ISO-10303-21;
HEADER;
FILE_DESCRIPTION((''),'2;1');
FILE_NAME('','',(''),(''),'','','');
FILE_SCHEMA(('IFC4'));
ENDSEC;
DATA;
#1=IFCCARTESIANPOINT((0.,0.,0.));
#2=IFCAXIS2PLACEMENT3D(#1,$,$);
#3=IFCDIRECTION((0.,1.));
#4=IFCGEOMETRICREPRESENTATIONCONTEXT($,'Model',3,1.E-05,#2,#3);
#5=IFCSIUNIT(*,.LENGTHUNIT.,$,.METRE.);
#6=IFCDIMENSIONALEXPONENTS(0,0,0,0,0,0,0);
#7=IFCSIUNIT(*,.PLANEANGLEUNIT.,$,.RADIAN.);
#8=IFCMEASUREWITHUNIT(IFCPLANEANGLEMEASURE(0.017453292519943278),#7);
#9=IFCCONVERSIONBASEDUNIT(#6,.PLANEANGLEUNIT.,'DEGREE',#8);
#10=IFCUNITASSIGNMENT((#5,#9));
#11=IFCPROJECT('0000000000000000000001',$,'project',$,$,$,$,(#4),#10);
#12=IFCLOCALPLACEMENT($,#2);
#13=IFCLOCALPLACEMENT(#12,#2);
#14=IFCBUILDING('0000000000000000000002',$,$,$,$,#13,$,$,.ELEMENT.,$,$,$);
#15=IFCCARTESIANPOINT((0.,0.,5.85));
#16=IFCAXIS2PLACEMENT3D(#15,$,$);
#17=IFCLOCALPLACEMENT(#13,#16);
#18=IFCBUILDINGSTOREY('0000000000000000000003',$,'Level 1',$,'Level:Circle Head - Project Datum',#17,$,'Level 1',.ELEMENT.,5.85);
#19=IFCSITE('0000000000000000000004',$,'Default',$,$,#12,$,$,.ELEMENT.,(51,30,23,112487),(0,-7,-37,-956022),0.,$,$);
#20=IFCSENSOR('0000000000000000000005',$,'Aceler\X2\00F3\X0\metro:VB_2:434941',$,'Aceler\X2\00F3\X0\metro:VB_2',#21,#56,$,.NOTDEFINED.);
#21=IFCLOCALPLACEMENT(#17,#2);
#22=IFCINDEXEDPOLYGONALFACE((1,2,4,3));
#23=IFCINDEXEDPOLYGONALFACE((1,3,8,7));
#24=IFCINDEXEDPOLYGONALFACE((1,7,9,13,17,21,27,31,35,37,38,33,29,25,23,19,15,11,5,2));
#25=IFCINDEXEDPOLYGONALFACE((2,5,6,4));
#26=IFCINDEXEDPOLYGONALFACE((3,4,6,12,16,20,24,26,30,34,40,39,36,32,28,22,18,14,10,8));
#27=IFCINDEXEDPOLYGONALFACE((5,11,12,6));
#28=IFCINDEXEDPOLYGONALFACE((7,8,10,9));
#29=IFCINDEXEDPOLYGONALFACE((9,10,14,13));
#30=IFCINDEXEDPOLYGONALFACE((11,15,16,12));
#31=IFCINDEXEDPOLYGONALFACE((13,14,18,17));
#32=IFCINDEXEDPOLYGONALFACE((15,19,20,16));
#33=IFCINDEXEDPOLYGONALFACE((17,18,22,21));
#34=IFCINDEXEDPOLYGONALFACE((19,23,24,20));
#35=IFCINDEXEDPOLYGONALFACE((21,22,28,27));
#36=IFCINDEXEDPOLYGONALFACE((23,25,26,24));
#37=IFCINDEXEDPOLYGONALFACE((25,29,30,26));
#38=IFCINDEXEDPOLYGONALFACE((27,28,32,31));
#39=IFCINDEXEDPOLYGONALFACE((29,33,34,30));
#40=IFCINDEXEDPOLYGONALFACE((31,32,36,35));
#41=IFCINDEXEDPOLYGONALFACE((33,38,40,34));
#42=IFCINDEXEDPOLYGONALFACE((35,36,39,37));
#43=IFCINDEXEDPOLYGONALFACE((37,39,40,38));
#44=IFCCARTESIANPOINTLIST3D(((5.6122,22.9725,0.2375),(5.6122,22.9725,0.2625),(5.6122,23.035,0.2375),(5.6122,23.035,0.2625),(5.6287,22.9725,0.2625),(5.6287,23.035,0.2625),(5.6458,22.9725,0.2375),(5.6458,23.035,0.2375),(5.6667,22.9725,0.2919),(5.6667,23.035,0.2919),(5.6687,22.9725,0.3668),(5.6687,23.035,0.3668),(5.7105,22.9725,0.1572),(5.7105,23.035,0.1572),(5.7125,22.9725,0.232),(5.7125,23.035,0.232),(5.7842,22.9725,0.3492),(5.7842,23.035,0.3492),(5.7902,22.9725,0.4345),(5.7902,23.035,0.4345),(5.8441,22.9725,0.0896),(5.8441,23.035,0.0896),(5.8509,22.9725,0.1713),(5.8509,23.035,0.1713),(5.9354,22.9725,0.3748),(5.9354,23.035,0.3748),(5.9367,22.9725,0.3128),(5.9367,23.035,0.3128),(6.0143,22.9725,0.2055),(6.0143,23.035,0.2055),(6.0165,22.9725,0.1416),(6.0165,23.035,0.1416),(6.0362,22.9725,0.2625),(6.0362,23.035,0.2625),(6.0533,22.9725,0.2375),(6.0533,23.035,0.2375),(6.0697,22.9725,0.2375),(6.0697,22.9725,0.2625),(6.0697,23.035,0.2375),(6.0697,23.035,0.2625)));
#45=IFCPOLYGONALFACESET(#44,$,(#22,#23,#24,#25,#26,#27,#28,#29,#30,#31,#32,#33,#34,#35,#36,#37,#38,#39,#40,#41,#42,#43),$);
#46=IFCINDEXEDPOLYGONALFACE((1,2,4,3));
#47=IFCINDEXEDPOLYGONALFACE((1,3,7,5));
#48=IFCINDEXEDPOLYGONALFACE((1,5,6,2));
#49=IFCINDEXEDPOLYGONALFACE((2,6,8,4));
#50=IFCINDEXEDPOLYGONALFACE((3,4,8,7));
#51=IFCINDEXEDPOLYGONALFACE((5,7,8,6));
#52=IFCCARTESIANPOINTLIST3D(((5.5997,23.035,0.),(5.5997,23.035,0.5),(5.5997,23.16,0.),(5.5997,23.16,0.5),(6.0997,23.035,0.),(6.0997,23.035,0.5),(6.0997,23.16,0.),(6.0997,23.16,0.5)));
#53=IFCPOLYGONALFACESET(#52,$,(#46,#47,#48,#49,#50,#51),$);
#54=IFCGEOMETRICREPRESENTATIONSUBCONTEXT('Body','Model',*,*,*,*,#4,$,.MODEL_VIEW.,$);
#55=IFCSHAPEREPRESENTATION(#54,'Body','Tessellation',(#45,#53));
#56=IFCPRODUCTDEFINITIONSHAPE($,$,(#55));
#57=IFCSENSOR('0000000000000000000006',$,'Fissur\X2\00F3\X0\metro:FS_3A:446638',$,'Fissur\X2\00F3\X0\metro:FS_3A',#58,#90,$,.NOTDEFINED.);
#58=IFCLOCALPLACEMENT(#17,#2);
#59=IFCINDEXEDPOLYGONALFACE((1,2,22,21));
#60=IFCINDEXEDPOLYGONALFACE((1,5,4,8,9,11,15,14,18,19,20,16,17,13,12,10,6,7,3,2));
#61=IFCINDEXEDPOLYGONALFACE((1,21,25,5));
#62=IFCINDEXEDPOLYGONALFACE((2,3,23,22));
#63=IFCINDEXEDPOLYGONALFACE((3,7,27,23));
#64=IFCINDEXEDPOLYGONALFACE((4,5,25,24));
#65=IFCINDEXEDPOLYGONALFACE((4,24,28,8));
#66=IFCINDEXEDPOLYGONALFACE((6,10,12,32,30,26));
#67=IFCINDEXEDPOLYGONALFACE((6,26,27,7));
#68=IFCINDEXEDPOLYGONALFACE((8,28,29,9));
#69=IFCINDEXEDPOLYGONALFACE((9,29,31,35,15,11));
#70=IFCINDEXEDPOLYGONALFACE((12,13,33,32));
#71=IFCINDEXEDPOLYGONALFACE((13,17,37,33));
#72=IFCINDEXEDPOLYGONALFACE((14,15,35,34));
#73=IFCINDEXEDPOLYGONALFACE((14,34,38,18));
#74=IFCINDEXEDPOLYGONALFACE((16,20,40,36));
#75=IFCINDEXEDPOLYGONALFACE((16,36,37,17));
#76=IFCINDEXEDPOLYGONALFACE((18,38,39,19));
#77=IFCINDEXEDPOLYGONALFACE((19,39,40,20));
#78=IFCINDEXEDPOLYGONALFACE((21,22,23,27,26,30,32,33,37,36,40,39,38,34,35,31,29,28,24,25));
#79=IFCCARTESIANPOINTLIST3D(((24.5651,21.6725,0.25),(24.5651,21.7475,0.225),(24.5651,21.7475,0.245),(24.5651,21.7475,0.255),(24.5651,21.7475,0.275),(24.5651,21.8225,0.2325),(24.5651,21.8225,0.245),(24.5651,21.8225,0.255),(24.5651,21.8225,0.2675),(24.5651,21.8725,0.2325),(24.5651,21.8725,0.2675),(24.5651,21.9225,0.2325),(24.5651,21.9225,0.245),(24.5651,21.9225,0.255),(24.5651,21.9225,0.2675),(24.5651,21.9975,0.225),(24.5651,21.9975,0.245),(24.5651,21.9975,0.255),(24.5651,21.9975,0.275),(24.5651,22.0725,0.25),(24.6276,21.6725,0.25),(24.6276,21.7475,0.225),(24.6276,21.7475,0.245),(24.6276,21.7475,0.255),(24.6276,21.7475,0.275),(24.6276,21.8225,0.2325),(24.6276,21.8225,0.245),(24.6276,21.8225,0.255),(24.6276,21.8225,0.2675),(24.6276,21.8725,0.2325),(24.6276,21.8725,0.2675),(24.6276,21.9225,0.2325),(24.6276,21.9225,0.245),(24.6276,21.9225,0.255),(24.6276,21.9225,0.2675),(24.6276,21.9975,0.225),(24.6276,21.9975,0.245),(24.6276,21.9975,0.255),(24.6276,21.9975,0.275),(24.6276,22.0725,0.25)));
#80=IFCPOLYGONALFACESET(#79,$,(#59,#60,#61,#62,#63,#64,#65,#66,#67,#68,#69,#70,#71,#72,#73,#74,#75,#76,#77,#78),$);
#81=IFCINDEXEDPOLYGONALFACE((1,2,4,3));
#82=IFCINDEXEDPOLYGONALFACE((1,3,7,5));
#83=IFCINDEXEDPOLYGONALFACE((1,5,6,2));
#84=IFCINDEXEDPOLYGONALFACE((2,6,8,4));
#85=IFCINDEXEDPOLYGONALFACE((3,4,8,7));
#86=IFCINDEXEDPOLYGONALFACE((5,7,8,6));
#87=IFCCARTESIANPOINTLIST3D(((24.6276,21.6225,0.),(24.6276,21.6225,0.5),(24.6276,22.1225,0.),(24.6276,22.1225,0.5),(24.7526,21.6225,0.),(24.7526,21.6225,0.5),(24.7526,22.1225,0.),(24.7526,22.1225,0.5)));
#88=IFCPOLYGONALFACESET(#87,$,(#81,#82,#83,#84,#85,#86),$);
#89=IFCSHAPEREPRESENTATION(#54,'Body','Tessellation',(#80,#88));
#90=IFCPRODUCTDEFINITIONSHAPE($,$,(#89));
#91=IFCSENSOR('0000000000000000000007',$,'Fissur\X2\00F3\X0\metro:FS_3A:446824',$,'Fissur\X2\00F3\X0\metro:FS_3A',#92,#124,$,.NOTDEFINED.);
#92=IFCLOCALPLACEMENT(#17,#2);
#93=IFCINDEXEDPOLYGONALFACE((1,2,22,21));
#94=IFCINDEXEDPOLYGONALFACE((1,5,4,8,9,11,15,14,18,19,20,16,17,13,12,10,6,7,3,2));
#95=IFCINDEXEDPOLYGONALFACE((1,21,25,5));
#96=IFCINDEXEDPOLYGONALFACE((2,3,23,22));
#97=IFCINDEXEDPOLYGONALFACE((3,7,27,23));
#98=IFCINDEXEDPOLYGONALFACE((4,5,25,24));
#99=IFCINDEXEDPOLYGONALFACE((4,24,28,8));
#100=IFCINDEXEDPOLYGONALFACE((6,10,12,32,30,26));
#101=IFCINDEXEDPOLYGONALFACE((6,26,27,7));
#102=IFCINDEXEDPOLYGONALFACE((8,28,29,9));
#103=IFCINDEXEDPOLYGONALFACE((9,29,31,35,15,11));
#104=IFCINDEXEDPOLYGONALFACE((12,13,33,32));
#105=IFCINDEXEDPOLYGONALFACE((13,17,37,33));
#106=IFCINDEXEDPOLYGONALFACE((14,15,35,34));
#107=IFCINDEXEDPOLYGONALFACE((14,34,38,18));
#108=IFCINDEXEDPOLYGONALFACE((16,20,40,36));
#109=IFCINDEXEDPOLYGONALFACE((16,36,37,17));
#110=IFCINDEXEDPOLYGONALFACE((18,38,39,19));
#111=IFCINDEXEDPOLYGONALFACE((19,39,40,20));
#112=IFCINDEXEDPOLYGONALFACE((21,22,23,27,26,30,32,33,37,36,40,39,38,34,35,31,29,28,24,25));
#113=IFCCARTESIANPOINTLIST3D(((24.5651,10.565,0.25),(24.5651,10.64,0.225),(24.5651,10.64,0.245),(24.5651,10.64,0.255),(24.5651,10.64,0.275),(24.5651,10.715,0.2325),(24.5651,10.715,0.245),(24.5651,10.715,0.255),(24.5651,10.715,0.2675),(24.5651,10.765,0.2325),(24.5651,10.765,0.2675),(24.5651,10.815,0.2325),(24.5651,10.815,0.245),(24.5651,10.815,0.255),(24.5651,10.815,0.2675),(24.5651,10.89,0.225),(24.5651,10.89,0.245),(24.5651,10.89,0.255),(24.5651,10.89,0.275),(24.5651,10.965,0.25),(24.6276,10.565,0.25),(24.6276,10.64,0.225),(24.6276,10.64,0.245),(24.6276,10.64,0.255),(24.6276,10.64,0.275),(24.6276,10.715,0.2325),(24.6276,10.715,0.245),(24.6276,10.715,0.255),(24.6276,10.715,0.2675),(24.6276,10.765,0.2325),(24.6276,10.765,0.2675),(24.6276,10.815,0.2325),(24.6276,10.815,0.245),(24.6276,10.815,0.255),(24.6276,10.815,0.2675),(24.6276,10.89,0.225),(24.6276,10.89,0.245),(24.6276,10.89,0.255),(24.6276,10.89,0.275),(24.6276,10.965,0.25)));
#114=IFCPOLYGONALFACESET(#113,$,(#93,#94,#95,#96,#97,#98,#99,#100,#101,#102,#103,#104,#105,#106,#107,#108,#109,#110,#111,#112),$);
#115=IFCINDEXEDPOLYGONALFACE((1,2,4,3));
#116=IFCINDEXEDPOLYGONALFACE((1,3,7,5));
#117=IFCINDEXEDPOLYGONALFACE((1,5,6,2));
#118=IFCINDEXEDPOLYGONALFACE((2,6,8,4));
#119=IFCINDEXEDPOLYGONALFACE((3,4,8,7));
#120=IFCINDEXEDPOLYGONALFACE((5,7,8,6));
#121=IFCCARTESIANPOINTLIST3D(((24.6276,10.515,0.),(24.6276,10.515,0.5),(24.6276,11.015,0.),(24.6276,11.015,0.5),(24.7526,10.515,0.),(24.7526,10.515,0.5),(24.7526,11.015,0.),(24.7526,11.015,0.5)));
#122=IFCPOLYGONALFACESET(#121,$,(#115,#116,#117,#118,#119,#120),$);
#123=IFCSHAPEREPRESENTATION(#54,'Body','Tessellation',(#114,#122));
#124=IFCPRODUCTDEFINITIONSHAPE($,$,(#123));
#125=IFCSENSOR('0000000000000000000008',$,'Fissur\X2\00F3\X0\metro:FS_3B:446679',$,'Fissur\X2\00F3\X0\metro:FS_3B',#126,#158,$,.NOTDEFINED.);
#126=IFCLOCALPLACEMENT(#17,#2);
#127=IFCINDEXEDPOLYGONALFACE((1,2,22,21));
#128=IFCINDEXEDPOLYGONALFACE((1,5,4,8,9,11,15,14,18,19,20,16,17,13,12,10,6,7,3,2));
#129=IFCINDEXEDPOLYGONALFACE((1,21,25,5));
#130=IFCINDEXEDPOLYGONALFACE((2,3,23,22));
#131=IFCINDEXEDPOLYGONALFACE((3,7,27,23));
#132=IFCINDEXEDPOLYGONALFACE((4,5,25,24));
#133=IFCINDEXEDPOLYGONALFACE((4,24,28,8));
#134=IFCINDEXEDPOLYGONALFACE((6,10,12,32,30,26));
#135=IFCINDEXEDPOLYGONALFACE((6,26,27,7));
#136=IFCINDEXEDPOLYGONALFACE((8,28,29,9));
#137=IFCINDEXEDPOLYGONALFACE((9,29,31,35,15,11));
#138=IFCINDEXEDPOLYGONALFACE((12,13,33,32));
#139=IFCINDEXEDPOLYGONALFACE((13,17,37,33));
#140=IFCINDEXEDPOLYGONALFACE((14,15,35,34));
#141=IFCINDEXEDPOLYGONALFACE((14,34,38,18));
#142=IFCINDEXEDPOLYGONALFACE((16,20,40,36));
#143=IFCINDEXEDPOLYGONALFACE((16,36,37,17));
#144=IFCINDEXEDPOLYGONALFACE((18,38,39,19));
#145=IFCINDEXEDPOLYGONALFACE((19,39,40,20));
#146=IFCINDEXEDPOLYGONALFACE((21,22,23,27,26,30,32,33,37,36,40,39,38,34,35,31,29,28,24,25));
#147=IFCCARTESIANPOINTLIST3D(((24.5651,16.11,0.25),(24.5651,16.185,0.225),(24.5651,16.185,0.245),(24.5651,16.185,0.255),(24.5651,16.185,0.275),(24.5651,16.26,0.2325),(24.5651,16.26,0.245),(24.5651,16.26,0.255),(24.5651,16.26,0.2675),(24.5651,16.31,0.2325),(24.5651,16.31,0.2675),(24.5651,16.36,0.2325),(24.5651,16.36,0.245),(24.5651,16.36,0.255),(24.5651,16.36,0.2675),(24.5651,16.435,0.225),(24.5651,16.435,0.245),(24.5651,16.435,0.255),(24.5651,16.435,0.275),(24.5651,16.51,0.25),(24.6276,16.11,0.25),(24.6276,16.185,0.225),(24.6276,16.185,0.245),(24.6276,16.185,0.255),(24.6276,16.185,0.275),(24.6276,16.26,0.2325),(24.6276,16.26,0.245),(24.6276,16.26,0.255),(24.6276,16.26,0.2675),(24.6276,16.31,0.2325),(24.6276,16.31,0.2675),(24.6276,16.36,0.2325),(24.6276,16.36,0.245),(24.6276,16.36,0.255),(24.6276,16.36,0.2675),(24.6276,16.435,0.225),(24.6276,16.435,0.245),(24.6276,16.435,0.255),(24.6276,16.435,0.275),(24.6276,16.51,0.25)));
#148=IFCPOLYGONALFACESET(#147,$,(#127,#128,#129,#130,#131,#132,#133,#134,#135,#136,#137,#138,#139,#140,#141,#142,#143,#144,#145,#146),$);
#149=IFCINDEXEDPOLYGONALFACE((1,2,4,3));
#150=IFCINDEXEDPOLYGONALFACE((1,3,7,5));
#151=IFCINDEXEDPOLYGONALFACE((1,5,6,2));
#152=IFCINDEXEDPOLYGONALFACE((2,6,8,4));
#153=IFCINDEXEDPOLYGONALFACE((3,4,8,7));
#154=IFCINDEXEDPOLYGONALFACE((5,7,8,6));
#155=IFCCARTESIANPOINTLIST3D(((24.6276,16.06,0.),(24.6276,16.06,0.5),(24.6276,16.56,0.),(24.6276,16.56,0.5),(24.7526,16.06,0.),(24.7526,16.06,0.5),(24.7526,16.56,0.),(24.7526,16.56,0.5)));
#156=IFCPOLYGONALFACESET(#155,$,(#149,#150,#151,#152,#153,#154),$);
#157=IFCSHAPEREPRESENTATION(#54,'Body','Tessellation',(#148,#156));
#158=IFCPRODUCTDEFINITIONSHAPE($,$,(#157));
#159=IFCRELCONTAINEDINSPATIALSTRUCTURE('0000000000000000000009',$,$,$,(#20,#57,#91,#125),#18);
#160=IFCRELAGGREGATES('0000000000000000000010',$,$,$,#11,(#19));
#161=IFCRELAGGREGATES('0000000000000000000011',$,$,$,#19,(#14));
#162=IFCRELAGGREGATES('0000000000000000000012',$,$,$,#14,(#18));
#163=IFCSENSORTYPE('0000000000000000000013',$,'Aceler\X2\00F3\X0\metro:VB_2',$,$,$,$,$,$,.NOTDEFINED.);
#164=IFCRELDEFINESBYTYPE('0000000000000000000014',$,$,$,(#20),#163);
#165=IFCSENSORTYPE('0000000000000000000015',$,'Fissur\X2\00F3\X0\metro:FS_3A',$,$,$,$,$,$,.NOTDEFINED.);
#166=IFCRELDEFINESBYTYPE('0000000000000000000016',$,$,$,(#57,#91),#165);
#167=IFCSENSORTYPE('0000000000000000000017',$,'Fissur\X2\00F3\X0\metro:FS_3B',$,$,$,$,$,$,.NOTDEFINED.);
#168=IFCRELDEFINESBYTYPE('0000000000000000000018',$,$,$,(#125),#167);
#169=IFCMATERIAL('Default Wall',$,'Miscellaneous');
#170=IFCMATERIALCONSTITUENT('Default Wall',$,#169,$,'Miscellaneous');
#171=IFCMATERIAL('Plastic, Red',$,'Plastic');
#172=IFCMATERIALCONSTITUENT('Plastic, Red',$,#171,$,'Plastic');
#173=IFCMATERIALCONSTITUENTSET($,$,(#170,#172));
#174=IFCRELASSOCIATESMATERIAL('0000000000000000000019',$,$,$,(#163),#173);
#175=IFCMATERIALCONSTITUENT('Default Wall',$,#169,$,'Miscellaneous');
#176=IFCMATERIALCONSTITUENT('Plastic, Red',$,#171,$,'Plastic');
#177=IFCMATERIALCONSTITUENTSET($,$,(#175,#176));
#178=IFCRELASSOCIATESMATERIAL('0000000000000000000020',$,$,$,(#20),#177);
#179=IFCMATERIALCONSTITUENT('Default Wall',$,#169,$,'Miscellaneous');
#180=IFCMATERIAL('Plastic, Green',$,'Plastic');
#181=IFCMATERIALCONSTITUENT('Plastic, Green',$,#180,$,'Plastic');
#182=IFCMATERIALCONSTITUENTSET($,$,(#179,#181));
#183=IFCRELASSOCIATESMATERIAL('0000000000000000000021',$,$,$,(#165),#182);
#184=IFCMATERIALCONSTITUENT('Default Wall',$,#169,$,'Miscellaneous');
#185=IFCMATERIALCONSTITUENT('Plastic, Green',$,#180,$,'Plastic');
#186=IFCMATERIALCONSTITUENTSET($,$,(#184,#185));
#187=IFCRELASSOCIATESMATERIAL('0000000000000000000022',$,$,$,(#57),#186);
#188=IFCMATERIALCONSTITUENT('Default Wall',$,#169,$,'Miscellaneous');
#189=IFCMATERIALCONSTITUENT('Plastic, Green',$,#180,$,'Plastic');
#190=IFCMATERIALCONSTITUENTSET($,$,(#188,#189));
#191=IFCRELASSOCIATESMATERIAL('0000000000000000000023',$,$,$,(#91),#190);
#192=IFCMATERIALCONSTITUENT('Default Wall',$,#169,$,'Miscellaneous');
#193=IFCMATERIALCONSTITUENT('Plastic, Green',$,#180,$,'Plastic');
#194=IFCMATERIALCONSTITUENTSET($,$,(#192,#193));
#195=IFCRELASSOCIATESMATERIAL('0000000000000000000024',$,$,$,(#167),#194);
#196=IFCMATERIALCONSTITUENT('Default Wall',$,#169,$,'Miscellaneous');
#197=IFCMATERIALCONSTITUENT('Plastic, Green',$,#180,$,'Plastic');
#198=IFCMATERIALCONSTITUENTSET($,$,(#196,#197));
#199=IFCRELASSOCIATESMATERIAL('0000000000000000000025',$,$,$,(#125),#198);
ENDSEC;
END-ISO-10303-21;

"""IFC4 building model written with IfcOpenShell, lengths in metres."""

from ifc_helpers import new_model, entity, si_unit, converted_unit, direction, frame, origin, place, context, subcontext, project, spatial, indexed_curve, outline, extrude, source, transform, mapped, material, constituent, constituent_set, type_object, type_shapes, element, save


model = new_model("IFC4")

# Units and contexts
model_context = context("Model", 3, precision=1e-05, world=origin(), true_north=direction((0.0, 1.0)))
body_context = subcontext(model_context, "Body", "Model", "MODEL_VIEW")
ifc_project = project(units=[si_unit("LENGTHUNIT", "METRE"), converted_unit("PLANEANGLEUNIT", "DEGREE", entity("IfcPlaneAngleMeasure", 0.017453292519943278), si_unit("PLANEANGLEUNIT", "RADIAN"), dimensions=[0, 0, 0, 0, 0, 0, 0])], contexts=[model_context])

# Site, building, storey
site_placement = place(None, origin())
site = spatial("IfcSite", under=ifc_project, at=site_placement, Name="Default", CompositionType="ELEMENT", RefLatitude=(51, 30, 23, 112487), RefLongitude=(0, -7, -37, -956022), RefElevation=0.0)
building_placement = place(site_placement, origin())
building = spatial("IfcBuilding", under=site, at=building_placement, CompositionType="ELEMENT")
storey_placement = place(building_placement, frame((0.0, 0.0, 5.85)))
storey = spatial("IfcBuildingStorey", under=building, at=storey_placement, Name="Level 1", ObjectType="Level:Circle Head - Project Datum", LongName="Level 1", CompositionType="ELEMENT", Elevation=5.85)

# Sensors
ifc_material_1 = material(Name="Default Wall", Category="Miscellaneous")
ifc_constituent_1 = constituent(ifc_material_1, Name="Default Wall", Category="Miscellaneous")
ifc_material_2 = material(Name="Plastic, Red", Category="Plastic")
ifc_constituent_2 = constituent(ifc_material_2, Name="Plastic, Red", Category="Plastic")
ifc_constituent_set_1 = constituent_set(constituents=[ifc_constituent_1, ifc_constituent_2])
ifc_constituent_3 = constituent(ifc_material_1, Name="Default Wall", Category="Miscellaneous")
ifc_constituent_4 = constituent(ifc_material_2, Name="Plastic, Red", Category="Plastic")
ifc_constituent_set_2 = constituent_set(constituents=[ifc_constituent_3, ifc_constituent_4])
sensor_type_1 = type_object("IfcSensorType", Name="Acelerómetro:VB_2", PredefinedType="NOTDEFINED", material=ifc_constituent_set_2)
shared_shape_1 = source(origin(), body_context, "Body", "SweptSolid", [
    extrude(outline(indexed_curve([(-0.0675, -0.1929), (0.0442, -0.1929), (-0.0659, -0.1038), (0.1509, -0.1038), (-0.073, 0.0473), (0.1473, 0.0532), (0.0176, 0.1875), (0.0786, 0.1875), (0.0906, 0.2189), (0.0673, 0.2278), (0.0614, 0.2125), (-0.0413, 0.2125), (0.0899, 0.0767), (-0.1517, 0.0702), (0.0692, -0.0788), (-0.1365, -0.0788), (-0.0264, -0.1679), (-0.0847, -0.1679), (-0.0967, -0.1993), (-0.0734, -0.2082), (-0.0675, -0.1929)], self_intersect=False)), frame((-0.0168, -0.125, 0.2564), z_axis=(0.0, 1.0, 0.0), x_axis=(0.358368, 0.0, 0.93358)), (0.0, 0.0, 1.0), 0.0625),
    extrude(outline(indexed_curve([(-0.25, -0.0625), (0.25, -0.0625), (0.25, 0.0625), (-0.25, 0.0625), (-0.25, -0.0625)], self_intersect=False)), frame((0.0, 0.0, 0.0), z_axis=(0.0, 0.0, 1.0), x_axis=(-1.0, 0.0, 0.0)), (0.0, 0.0, 1.0), 0.5),
])
type_shapes(sensor_type_1, [shared_shape_1])
sensor_1_placement = place(storey_placement, frame((5.8497, 23.0975, 0.0)))
element("IfcSensor", 1, at=sensor_1_placement, inside=storey, type_object=sensor_type_1, material=ifc_constituent_set_1, Name="Acelerómetro:VB_2:434941", ObjectType="Acelerómetro:VB_2", PredefinedType="NOTDEFINED", context=body_context, shape_type="MappedRepresentation", body=[
    mapped(shared_shape_1, transform((0.0, 0.0, 0.0), scale=1.0)),
])
ifc_constituent_5 = constituent(ifc_material_1, Name="Default Wall", Category="Miscellaneous")
ifc_material_3 = material(Name="Plastic, Green", Category="Plastic")
ifc_constituent_6 = constituent(ifc_material_3, Name="Plastic, Green", Category="Plastic")
ifc_constituent_set_3 = constituent_set(constituents=[ifc_constituent_5, ifc_constituent_6])
ifc_constituent_7 = constituent(ifc_material_1, Name="Default Wall", Category="Miscellaneous")
ifc_constituent_8 = constituent(ifc_material_3, Name="Plastic, Green", Category="Plastic")
ifc_constituent_set_4 = constituent_set(constituents=[ifc_constituent_7, ifc_constituent_8])
sensor_type_2 = type_object("IfcSensorType", Name="Fissurómetro:FS_3A", PredefinedType="NOTDEFINED", material=ifc_constituent_set_4)
shared_shape_2 = source(origin(), body_context, "Body", "SweptSolid", [
    extrude(outline(indexed_curve([(-0.025, -0.125), (0.0, -0.2), (0.025, -0.125), (0.005, -0.125), (0.005, -0.05), (0.0175, -0.05), (0.0175, 0.0), (0.0175, 0.05), (0.005, 0.05), (0.005, 0.125), (0.025, 0.125), (0.0, 0.2), (-0.025, 0.125), (-0.005, 0.125), (-0.005, 0.05), (-0.0175, 0.05), (-0.0175, 0.0), (-0.0175, -0.05), (-0.005, -0.05), (-0.005, -0.125), (-0.025, -0.125)], self_intersect=False)), frame((0.0, -0.125, 0.25), z_axis=(0.0, -1.0, 0.0), x_axis=(0.0, 0.0, -1.0)), (0.0, 0.0, -1.0), 0.0625),
    extrude(outline(indexed_curve([(-0.25, -0.0625), (0.25, -0.0625), (0.25, 0.0625), (-0.25, 0.0625), (-0.25, -0.0625)], self_intersect=False)), frame((0.0, 0.0, 0.0), z_axis=(0.0, 0.0, 1.0), x_axis=(-1.0, 0.0, 0.0)), (0.0, 0.0, 1.0), 0.5),
])
type_shapes(sensor_type_2, [shared_shape_2])
sensor_2_placement = place(storey_placement, frame((24.6901, 21.8725, 0.0), z_axis=(0.0, 0.0, 1.0), x_axis=(0.0, -1.0, 0.0)))
element("IfcSensor", 2, at=sensor_2_placement, inside=storey, type_object=sensor_type_2, material=ifc_constituent_set_3, Name="Fissurómetro:FS_3A:446638", ObjectType="Fissurómetro:FS_3A", PredefinedType="NOTDEFINED", context=body_context, shape_type="MappedRepresentation", body=[
    mapped(shared_shape_2, transform((0.0, 0.0, 0.0), scale=1.0)),
])
ifc_constituent_9 = constituent(ifc_material_1, Name="Default Wall", Category="Miscellaneous")
ifc_constituent_10 = constituent(ifc_material_3, Name="Plastic, Green", Category="Plastic")
ifc_constituent_set_5 = constituent_set(constituents=[ifc_constituent_9, ifc_constituent_10])
sensor_3_placement = place(storey_placement, frame((24.6901, 10.765, 0.0), z_axis=(0.0, 0.0, 1.0), x_axis=(0.0, -1.0, 0.0)))
element("IfcSensor", 3, at=sensor_3_placement, inside=storey, type_object=sensor_type_2, material=ifc_constituent_set_5, Name="Fissurómetro:FS_3A:446824", ObjectType="Fissurómetro:FS_3A", PredefinedType="NOTDEFINED", context=body_context, shape_type="MappedRepresentation", body=[
    mapped(shared_shape_2, transform((0.0, 0.0, 0.0), scale=1.0)),
])
ifc_constituent_11 = constituent(ifc_material_1, Name="Default Wall", Category="Miscellaneous")
ifc_constituent_12 = constituent(ifc_material_3, Name="Plastic, Green", Category="Plastic")
ifc_constituent_set_6 = constituent_set(constituents=[ifc_constituent_11, ifc_constituent_12])
ifc_constituent_13 = constituent(ifc_material_1, Name="Default Wall", Category="Miscellaneous")
ifc_constituent_14 = constituent(ifc_material_3, Name="Plastic, Green", Category="Plastic")
ifc_constituent_set_7 = constituent_set(constituents=[ifc_constituent_13, ifc_constituent_14])
sensor_type_3 = type_object("IfcSensorType", Name="Fissurómetro:FS_3B", PredefinedType="NOTDEFINED", material=ifc_constituent_set_7)
shared_shape_3 = source(origin(), body_context, "Body", "SweptSolid", [
    extrude(outline(indexed_curve([(-0.025, -0.125), (0.0, -0.2), (0.025, -0.125), (0.005, -0.125), (0.005, -0.05), (0.0175, -0.05), (0.0175, 0.0), (0.0175, 0.05), (0.005, 0.05), (0.005, 0.125), (0.025, 0.125), (0.0, 0.2), (-0.025, 0.125), (-0.005, 0.125), (-0.005, 0.05), (-0.0175, 0.05), (-0.0175, 0.0), (-0.0175, -0.05), (-0.005, -0.05), (-0.005, -0.125), (-0.025, -0.125)], self_intersect=False)), frame((0.0, -0.125, 0.25), z_axis=(0.0, -1.0, 0.0), x_axis=(0.0, 0.0, -1.0)), (0.0, 0.0, -1.0), 0.0625),
    extrude(outline(indexed_curve([(-0.25, -0.0625), (0.25, -0.0625), (0.25, 0.0625), (-0.25, 0.0625), (-0.25, -0.0625)], self_intersect=False)), frame((0.0, 0.0, 0.0), z_axis=(0.0, 0.0, 1.0), x_axis=(-1.0, 0.0, 0.0)), (0.0, 0.0, 1.0), 0.5),
])
type_shapes(sensor_type_3, [shared_shape_3])
sensor_4_placement = place(storey_placement, frame((24.6901, 16.31, 0.0), z_axis=(0.0, 0.0, 1.0), x_axis=(0.0, -1.0, 0.0)))
element("IfcSensor", 4, at=sensor_4_placement, inside=storey, type_object=sensor_type_3, material=ifc_constituent_set_6, Name="Fissurómetro:FS_3B:446679", ObjectType="Fissurómetro:FS_3B", PredefinedType="NOTDEFINED", context=body_context, shape_type="MappedRepresentation", body=[
    mapped(shared_shape_3, transform((0.0, 0.0, 0.0), scale=1.0)),
])

save(model, "model.ifc")
